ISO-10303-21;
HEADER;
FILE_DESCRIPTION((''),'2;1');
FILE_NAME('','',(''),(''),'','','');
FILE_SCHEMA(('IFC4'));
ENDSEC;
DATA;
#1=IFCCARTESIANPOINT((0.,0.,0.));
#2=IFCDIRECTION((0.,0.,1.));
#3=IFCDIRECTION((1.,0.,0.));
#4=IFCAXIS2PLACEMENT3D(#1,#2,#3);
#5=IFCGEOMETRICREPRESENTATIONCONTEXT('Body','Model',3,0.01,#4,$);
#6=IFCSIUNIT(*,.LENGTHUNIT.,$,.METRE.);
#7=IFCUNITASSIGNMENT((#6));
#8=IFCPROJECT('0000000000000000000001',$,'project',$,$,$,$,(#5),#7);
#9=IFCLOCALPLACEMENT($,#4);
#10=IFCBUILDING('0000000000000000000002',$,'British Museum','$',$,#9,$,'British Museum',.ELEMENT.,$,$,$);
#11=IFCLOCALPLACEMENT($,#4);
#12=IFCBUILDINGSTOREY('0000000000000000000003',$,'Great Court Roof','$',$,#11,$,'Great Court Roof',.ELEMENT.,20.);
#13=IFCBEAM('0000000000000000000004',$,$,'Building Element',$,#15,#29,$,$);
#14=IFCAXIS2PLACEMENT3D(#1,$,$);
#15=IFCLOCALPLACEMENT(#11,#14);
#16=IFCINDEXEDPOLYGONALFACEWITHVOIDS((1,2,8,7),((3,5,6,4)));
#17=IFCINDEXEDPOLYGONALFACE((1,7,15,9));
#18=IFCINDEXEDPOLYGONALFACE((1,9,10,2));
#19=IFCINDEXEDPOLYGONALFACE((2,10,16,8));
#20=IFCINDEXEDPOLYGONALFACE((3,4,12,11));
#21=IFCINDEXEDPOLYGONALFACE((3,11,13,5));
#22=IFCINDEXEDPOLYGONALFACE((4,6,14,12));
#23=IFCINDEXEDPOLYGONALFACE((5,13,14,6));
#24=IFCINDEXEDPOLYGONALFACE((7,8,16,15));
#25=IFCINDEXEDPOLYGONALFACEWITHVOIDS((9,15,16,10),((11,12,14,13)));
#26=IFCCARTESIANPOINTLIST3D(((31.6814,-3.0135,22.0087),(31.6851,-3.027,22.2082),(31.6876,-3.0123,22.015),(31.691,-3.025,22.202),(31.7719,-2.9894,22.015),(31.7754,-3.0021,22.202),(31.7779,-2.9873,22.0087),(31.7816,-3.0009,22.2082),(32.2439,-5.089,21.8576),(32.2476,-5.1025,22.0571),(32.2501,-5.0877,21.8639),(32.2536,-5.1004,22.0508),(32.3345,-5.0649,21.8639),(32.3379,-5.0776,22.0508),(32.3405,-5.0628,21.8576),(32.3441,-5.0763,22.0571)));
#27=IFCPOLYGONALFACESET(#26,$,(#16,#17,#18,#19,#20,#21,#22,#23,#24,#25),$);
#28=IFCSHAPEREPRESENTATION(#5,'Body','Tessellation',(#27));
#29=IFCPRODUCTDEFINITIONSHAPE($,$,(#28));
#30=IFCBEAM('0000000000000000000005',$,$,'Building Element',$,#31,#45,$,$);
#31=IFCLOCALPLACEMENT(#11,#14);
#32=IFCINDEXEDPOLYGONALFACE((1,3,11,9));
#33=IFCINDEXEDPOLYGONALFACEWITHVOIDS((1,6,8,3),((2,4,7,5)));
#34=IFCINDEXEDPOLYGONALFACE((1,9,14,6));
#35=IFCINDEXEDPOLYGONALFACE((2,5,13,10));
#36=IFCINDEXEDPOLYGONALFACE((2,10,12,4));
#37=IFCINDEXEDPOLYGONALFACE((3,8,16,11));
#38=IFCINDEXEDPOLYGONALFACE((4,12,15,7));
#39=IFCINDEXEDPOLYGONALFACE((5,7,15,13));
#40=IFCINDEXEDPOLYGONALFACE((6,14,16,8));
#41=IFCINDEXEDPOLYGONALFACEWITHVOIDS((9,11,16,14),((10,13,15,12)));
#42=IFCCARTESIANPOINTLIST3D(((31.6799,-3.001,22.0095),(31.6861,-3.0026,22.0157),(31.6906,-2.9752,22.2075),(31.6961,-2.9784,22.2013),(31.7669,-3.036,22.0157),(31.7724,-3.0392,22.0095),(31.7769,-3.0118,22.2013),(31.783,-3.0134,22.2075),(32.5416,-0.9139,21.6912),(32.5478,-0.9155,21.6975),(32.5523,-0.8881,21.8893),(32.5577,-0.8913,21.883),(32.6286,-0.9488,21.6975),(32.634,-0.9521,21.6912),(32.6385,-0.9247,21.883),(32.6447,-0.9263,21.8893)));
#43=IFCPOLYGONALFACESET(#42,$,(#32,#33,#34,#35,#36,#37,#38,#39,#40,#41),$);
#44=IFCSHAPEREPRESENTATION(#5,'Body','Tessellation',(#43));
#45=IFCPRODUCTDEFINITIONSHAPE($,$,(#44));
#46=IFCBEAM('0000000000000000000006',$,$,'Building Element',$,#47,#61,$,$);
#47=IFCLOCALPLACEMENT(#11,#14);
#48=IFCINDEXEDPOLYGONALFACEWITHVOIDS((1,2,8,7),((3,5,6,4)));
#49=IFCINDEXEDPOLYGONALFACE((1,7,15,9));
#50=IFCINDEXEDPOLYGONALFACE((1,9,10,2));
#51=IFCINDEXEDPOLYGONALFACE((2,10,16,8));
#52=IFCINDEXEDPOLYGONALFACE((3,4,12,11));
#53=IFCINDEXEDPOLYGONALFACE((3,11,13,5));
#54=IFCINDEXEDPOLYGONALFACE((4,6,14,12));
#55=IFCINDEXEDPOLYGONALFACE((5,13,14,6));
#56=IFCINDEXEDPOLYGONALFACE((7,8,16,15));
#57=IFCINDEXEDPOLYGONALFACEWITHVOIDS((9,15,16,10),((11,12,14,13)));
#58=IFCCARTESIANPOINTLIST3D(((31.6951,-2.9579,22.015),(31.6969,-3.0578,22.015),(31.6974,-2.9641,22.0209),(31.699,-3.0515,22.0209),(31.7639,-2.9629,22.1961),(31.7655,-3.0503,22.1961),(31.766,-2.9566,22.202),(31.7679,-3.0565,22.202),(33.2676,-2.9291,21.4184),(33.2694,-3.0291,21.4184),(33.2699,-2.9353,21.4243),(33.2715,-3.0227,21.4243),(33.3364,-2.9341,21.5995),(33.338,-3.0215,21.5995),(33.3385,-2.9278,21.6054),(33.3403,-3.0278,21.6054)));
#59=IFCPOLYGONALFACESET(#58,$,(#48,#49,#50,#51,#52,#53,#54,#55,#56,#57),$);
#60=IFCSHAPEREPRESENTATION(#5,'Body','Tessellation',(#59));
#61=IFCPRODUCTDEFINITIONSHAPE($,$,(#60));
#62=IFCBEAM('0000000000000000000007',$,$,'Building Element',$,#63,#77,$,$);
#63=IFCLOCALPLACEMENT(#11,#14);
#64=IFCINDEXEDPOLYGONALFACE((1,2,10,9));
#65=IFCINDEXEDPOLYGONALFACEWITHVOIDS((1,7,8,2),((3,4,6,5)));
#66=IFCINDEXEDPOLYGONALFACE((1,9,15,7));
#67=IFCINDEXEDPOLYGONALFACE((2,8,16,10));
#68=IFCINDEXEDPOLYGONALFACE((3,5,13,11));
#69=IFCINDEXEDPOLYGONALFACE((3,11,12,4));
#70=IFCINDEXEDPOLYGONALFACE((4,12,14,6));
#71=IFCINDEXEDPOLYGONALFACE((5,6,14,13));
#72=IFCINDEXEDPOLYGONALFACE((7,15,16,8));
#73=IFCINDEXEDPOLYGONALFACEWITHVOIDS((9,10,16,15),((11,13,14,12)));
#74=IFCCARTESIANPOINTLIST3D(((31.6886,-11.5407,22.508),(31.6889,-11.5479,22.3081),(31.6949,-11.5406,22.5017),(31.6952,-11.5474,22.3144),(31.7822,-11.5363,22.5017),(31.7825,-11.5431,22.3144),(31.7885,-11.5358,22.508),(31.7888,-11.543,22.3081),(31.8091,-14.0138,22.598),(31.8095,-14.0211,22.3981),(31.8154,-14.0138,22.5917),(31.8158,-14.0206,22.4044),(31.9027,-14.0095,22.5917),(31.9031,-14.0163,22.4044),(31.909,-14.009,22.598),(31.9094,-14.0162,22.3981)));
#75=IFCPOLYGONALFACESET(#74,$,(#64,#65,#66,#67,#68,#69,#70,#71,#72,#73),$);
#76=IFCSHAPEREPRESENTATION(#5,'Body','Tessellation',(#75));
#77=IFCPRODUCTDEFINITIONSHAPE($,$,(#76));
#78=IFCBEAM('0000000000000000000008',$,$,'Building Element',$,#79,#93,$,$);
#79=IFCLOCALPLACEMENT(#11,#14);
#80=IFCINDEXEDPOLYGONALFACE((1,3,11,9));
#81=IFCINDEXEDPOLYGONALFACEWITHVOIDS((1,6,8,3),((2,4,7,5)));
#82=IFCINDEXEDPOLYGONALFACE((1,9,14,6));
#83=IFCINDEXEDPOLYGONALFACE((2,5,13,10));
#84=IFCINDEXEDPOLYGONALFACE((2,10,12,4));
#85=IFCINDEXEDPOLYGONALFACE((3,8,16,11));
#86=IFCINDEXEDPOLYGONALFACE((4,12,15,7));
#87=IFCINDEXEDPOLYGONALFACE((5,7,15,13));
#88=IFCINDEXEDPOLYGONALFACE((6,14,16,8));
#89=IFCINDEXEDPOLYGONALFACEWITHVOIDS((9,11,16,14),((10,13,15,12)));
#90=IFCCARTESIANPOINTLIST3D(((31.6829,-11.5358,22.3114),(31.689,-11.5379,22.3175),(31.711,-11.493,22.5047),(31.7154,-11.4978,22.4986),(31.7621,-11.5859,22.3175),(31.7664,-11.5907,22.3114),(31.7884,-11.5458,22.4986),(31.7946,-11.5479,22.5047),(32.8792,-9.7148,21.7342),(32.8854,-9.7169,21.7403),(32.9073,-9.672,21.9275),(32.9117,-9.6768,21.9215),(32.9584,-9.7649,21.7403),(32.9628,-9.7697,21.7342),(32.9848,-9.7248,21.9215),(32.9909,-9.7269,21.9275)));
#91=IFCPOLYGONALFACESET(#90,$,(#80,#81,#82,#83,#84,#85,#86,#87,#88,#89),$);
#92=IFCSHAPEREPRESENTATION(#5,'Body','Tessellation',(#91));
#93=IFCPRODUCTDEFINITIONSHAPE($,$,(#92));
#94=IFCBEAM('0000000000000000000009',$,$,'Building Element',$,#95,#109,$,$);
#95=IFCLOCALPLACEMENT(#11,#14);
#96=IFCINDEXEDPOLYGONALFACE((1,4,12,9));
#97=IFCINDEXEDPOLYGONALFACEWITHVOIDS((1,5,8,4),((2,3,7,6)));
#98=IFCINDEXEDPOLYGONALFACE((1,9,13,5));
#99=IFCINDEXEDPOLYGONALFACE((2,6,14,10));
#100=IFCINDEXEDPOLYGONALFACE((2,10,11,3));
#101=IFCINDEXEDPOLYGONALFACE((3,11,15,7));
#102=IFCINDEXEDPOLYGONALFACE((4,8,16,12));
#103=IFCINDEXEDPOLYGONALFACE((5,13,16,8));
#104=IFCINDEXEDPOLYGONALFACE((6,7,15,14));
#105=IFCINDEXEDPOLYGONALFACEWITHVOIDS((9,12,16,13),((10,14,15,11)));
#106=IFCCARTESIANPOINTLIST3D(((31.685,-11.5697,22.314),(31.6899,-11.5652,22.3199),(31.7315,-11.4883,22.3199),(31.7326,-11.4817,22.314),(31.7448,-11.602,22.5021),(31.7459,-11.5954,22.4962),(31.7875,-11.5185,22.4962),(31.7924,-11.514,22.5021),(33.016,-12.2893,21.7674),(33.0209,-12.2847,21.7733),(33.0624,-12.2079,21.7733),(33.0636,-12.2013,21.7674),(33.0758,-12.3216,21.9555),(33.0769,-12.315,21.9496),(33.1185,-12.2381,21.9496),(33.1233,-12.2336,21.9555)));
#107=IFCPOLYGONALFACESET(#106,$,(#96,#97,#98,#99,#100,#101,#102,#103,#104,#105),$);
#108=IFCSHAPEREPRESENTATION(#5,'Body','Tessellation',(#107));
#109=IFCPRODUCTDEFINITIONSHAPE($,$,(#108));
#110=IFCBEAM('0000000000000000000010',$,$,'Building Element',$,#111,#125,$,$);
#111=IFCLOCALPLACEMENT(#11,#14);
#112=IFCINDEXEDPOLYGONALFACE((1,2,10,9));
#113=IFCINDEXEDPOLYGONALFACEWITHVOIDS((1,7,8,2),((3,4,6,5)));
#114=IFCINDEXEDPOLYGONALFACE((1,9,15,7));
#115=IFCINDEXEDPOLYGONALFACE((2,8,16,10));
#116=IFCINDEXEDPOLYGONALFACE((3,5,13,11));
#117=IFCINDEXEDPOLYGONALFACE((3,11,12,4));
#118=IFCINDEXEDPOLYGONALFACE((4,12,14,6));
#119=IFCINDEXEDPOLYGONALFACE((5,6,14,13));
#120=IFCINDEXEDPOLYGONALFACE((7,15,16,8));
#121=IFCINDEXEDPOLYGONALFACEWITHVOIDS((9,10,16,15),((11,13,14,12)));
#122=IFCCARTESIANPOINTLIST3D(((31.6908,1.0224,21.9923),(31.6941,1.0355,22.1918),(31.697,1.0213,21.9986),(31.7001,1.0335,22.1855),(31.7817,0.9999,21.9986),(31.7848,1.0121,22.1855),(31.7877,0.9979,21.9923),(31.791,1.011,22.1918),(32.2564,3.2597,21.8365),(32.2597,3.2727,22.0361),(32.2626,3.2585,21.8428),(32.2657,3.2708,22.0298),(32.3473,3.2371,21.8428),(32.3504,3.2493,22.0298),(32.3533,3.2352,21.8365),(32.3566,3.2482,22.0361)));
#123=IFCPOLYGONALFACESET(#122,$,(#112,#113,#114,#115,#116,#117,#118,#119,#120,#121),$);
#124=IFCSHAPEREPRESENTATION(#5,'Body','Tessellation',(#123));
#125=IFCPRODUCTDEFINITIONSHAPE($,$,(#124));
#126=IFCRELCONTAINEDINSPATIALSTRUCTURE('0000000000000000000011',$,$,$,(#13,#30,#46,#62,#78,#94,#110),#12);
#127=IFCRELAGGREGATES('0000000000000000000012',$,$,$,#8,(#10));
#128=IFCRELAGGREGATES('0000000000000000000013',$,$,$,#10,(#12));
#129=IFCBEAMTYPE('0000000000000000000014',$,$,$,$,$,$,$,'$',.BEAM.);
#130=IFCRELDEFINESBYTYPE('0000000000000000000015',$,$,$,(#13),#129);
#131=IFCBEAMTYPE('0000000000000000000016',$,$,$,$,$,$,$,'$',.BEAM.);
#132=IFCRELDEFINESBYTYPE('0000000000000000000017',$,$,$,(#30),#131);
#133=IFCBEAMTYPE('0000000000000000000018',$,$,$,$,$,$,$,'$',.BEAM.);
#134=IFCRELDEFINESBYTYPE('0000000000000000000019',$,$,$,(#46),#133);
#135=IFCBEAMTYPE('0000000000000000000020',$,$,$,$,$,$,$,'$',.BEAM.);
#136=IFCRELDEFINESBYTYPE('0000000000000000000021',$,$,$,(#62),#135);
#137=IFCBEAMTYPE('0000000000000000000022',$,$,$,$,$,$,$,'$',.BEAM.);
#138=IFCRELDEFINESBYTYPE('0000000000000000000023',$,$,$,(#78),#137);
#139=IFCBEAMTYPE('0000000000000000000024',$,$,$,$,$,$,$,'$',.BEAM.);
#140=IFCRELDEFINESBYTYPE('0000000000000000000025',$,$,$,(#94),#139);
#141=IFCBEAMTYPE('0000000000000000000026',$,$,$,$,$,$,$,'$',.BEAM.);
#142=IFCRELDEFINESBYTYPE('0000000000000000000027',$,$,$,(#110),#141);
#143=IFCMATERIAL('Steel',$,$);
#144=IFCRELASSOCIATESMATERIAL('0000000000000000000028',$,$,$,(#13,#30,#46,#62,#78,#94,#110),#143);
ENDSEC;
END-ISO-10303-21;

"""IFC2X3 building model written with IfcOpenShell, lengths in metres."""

from ifc_helpers import new_model, si_unit, frame, origin_with_axes, origin_2d, place, context, project, spatial, hollow_rectangle, extrude, material, type_object, element, save


model = new_model("IFC2X3")

# Units and contexts
model_context = context("Model", 3, precision=0.01, world=origin_with_axes(), identifier="Body")
ifc_project = project(units=[si_unit("LENGTHUNIT", "METRE")], contexts=[model_context])

# Building, storey
building_placement = place(None, origin_with_axes())
building = spatial("IfcBuilding", under=ifc_project, at=building_placement, Name="British Museum", Description="$", LongName="British Museum", CompositionType="ELEMENT")
storey_placement = place(None, origin_with_axes())
storey = spatial("IfcBuildingStorey", under=building, at=storey_placement, Name="Great Court Roof", Description="$", LongName="Great Court Roof", CompositionType="ELEMENT", Elevation=20.0)

# Beams
ifc_material = material(Name="Steel")
beam_type_1 = type_object("IfcBeamType", ElementType="$", PredefinedType="BEAM")
beam_1_placement = place(None, origin_with_axes())
element("IfcBeam", 1, at=beam_1_placement, inside=storey, type_object=beam_type_1, material=ifc_material, Description="Building Element", context=model_context, shape_type="SweptSolid", body=[
    extrude(hollow_rectangle(XDim=0.1, YDim=0.2, WallThickness=0.0063, InnerFilletRadius=0.0, OuterFilletRadius=0.0, at=origin_2d()), frame((31.7315, -3.0072, 22.1085), z_axis=(0.260968, -0.962798, -0.070114), x_axis=(0.965173, 0.261612, 0.0)), (0.0, 0.0, 1.0), 2.1556),
])
beam_type_2 = type_object("IfcBeamType", ElementType="$", PredefinedType="BEAM")
beam_2_placement = place(None, origin_with_axes())
element("IfcBeam", 2, at=beam_2_placement, inside=storey, type_object=beam_type_2, material=ifc_material, Description="Building Element", context=model_context, shape_type="SweptSolid", body=[
    extrude(hollow_rectangle(XDim=0.1, YDim=0.2, WallThickness=0.0063, InnerFilletRadius=0.0, OuterFilletRadius=0.0, at=origin_2d()), frame((31.7315, -3.0072, 22.1085), z_axis=(0.377876, 0.915277, -0.139565), x_axis=(-0.924323, 0.381611, 0.0)), (0.0, 0.0, 1.0), 2.2803),
])
beam_type_3 = type_object("IfcBeamType", ElementType="$", PredefinedType="BEAM")
beam_3_placement = place(None, origin_with_axes())
element("IfcBeam", 3, at=beam_3_placement, inside=storey, type_object=beam_type_3, material=ifc_material, Description="Building Element", context=model_context, shape_type="SweptSolid", body=[
    extrude(hollow_rectangle(XDim=0.1, YDim=0.2, WallThickness=0.0063, InnerFilletRadius=0.0, OuterFilletRadius=0.0, at=origin_2d()), frame((31.7315, -3.0072, 22.1085), z_axis=(0.934828, 0.017098, -0.35469), x_axis=(-0.018287, 0.999833, 0.0)), (0.0, 0.0, 1.0), 1.6821),
])
beam_type_4 = type_object("IfcBeamType", ElementType="$", PredefinedType="BEAM")
beam_4_placement = place(None, origin_with_axes())
element("IfcBeam", 4, at=beam_4_placement, inside=storey, type_object=beam_type_4, material=ifc_material, Description="Building Element", context=model_context, shape_type="SweptSolid", body=[
    extrude(hollow_rectangle(XDim=0.1, YDim=0.2, WallThickness=0.0063, InnerFilletRadius=0.0, OuterFilletRadius=0.0, at=origin_2d()), frame((31.7387, -11.5419, 22.4081), z_axis=(0.048654, -0.998155, 0.036317), x_axis=(0.998814, 0.048686, 0.0)), (0.0, 0.0, 1.0), 2.4778),
])
beam_type_5 = type_object("IfcBeamType", ElementType="$", PredefinedType="BEAM")
beam_5_placement = place(None, origin_with_axes())
element("IfcBeam", 5, at=beam_5_placement, inside=storey, type_object=beam_type_5, material=ifc_material, Description="Building Element", context=model_context, shape_type="SweptSolid", body=[
    extrude(hollow_rectangle(XDim=0.1, YDim=0.2, WallThickness=0.0063, InnerFilletRadius=0.0, OuterFilletRadius=0.0, at=origin_2d()), frame((31.7387, -11.5419, 22.4081), z_axis=(0.530771, 0.807905, -0.256069), x_axis=(-0.835771, 0.549078, 0.0)), (0.0, 0.0, 1.0), 2.254),
])
beam_type_6 = type_object("IfcBeamType", ElementType="$", PredefinedType="BEAM")
beam_6_placement = place(None, origin_with_axes())
element("IfcBeam", 6, at=beam_6_placement, inside=storey, type_object=beam_type_6, material=ifc_material, Description="Building Element", context=model_context, shape_type="SweptSolid", body=[
    extrude(hollow_rectangle(XDim=0.1, YDim=0.2, WallThickness=0.0063, InnerFilletRadius=0.0, OuterFilletRadius=0.0, at=origin_2d()), frame((31.7387, -11.5419, 22.4081), z_axis=(0.827333, -0.447304, -0.339764), x_axis=(0.475597, 0.879664, 0.0)), (0.0, 0.0, 1.0), 1.6087),
])
beam_type_7 = type_object("IfcBeamType", ElementType="$", PredefinedType="BEAM")
beam_7_placement = place(None, origin_with_axes())
element("IfcBeam", 7, at=beam_7_placement, inside=storey, type_object=beam_type_7, material=ifc_material, Description="Building Element", context=model_context, shape_type="SweptSolid", body=[
    extrude(hollow_rectangle(XDim=0.1, YDim=0.2, WallThickness=0.0063, InnerFilletRadius=0.0, OuterFilletRadius=0.0, at=origin_2d()), frame((31.7409, 1.0167, 22.0921), z_axis=(0.244539, 0.967298, -0.067337), x_axis=(-0.969499, 0.245095, 0.0)), (0.0, 0.0, 1.0), 2.3129),
])

save(model, "model.ifc")
